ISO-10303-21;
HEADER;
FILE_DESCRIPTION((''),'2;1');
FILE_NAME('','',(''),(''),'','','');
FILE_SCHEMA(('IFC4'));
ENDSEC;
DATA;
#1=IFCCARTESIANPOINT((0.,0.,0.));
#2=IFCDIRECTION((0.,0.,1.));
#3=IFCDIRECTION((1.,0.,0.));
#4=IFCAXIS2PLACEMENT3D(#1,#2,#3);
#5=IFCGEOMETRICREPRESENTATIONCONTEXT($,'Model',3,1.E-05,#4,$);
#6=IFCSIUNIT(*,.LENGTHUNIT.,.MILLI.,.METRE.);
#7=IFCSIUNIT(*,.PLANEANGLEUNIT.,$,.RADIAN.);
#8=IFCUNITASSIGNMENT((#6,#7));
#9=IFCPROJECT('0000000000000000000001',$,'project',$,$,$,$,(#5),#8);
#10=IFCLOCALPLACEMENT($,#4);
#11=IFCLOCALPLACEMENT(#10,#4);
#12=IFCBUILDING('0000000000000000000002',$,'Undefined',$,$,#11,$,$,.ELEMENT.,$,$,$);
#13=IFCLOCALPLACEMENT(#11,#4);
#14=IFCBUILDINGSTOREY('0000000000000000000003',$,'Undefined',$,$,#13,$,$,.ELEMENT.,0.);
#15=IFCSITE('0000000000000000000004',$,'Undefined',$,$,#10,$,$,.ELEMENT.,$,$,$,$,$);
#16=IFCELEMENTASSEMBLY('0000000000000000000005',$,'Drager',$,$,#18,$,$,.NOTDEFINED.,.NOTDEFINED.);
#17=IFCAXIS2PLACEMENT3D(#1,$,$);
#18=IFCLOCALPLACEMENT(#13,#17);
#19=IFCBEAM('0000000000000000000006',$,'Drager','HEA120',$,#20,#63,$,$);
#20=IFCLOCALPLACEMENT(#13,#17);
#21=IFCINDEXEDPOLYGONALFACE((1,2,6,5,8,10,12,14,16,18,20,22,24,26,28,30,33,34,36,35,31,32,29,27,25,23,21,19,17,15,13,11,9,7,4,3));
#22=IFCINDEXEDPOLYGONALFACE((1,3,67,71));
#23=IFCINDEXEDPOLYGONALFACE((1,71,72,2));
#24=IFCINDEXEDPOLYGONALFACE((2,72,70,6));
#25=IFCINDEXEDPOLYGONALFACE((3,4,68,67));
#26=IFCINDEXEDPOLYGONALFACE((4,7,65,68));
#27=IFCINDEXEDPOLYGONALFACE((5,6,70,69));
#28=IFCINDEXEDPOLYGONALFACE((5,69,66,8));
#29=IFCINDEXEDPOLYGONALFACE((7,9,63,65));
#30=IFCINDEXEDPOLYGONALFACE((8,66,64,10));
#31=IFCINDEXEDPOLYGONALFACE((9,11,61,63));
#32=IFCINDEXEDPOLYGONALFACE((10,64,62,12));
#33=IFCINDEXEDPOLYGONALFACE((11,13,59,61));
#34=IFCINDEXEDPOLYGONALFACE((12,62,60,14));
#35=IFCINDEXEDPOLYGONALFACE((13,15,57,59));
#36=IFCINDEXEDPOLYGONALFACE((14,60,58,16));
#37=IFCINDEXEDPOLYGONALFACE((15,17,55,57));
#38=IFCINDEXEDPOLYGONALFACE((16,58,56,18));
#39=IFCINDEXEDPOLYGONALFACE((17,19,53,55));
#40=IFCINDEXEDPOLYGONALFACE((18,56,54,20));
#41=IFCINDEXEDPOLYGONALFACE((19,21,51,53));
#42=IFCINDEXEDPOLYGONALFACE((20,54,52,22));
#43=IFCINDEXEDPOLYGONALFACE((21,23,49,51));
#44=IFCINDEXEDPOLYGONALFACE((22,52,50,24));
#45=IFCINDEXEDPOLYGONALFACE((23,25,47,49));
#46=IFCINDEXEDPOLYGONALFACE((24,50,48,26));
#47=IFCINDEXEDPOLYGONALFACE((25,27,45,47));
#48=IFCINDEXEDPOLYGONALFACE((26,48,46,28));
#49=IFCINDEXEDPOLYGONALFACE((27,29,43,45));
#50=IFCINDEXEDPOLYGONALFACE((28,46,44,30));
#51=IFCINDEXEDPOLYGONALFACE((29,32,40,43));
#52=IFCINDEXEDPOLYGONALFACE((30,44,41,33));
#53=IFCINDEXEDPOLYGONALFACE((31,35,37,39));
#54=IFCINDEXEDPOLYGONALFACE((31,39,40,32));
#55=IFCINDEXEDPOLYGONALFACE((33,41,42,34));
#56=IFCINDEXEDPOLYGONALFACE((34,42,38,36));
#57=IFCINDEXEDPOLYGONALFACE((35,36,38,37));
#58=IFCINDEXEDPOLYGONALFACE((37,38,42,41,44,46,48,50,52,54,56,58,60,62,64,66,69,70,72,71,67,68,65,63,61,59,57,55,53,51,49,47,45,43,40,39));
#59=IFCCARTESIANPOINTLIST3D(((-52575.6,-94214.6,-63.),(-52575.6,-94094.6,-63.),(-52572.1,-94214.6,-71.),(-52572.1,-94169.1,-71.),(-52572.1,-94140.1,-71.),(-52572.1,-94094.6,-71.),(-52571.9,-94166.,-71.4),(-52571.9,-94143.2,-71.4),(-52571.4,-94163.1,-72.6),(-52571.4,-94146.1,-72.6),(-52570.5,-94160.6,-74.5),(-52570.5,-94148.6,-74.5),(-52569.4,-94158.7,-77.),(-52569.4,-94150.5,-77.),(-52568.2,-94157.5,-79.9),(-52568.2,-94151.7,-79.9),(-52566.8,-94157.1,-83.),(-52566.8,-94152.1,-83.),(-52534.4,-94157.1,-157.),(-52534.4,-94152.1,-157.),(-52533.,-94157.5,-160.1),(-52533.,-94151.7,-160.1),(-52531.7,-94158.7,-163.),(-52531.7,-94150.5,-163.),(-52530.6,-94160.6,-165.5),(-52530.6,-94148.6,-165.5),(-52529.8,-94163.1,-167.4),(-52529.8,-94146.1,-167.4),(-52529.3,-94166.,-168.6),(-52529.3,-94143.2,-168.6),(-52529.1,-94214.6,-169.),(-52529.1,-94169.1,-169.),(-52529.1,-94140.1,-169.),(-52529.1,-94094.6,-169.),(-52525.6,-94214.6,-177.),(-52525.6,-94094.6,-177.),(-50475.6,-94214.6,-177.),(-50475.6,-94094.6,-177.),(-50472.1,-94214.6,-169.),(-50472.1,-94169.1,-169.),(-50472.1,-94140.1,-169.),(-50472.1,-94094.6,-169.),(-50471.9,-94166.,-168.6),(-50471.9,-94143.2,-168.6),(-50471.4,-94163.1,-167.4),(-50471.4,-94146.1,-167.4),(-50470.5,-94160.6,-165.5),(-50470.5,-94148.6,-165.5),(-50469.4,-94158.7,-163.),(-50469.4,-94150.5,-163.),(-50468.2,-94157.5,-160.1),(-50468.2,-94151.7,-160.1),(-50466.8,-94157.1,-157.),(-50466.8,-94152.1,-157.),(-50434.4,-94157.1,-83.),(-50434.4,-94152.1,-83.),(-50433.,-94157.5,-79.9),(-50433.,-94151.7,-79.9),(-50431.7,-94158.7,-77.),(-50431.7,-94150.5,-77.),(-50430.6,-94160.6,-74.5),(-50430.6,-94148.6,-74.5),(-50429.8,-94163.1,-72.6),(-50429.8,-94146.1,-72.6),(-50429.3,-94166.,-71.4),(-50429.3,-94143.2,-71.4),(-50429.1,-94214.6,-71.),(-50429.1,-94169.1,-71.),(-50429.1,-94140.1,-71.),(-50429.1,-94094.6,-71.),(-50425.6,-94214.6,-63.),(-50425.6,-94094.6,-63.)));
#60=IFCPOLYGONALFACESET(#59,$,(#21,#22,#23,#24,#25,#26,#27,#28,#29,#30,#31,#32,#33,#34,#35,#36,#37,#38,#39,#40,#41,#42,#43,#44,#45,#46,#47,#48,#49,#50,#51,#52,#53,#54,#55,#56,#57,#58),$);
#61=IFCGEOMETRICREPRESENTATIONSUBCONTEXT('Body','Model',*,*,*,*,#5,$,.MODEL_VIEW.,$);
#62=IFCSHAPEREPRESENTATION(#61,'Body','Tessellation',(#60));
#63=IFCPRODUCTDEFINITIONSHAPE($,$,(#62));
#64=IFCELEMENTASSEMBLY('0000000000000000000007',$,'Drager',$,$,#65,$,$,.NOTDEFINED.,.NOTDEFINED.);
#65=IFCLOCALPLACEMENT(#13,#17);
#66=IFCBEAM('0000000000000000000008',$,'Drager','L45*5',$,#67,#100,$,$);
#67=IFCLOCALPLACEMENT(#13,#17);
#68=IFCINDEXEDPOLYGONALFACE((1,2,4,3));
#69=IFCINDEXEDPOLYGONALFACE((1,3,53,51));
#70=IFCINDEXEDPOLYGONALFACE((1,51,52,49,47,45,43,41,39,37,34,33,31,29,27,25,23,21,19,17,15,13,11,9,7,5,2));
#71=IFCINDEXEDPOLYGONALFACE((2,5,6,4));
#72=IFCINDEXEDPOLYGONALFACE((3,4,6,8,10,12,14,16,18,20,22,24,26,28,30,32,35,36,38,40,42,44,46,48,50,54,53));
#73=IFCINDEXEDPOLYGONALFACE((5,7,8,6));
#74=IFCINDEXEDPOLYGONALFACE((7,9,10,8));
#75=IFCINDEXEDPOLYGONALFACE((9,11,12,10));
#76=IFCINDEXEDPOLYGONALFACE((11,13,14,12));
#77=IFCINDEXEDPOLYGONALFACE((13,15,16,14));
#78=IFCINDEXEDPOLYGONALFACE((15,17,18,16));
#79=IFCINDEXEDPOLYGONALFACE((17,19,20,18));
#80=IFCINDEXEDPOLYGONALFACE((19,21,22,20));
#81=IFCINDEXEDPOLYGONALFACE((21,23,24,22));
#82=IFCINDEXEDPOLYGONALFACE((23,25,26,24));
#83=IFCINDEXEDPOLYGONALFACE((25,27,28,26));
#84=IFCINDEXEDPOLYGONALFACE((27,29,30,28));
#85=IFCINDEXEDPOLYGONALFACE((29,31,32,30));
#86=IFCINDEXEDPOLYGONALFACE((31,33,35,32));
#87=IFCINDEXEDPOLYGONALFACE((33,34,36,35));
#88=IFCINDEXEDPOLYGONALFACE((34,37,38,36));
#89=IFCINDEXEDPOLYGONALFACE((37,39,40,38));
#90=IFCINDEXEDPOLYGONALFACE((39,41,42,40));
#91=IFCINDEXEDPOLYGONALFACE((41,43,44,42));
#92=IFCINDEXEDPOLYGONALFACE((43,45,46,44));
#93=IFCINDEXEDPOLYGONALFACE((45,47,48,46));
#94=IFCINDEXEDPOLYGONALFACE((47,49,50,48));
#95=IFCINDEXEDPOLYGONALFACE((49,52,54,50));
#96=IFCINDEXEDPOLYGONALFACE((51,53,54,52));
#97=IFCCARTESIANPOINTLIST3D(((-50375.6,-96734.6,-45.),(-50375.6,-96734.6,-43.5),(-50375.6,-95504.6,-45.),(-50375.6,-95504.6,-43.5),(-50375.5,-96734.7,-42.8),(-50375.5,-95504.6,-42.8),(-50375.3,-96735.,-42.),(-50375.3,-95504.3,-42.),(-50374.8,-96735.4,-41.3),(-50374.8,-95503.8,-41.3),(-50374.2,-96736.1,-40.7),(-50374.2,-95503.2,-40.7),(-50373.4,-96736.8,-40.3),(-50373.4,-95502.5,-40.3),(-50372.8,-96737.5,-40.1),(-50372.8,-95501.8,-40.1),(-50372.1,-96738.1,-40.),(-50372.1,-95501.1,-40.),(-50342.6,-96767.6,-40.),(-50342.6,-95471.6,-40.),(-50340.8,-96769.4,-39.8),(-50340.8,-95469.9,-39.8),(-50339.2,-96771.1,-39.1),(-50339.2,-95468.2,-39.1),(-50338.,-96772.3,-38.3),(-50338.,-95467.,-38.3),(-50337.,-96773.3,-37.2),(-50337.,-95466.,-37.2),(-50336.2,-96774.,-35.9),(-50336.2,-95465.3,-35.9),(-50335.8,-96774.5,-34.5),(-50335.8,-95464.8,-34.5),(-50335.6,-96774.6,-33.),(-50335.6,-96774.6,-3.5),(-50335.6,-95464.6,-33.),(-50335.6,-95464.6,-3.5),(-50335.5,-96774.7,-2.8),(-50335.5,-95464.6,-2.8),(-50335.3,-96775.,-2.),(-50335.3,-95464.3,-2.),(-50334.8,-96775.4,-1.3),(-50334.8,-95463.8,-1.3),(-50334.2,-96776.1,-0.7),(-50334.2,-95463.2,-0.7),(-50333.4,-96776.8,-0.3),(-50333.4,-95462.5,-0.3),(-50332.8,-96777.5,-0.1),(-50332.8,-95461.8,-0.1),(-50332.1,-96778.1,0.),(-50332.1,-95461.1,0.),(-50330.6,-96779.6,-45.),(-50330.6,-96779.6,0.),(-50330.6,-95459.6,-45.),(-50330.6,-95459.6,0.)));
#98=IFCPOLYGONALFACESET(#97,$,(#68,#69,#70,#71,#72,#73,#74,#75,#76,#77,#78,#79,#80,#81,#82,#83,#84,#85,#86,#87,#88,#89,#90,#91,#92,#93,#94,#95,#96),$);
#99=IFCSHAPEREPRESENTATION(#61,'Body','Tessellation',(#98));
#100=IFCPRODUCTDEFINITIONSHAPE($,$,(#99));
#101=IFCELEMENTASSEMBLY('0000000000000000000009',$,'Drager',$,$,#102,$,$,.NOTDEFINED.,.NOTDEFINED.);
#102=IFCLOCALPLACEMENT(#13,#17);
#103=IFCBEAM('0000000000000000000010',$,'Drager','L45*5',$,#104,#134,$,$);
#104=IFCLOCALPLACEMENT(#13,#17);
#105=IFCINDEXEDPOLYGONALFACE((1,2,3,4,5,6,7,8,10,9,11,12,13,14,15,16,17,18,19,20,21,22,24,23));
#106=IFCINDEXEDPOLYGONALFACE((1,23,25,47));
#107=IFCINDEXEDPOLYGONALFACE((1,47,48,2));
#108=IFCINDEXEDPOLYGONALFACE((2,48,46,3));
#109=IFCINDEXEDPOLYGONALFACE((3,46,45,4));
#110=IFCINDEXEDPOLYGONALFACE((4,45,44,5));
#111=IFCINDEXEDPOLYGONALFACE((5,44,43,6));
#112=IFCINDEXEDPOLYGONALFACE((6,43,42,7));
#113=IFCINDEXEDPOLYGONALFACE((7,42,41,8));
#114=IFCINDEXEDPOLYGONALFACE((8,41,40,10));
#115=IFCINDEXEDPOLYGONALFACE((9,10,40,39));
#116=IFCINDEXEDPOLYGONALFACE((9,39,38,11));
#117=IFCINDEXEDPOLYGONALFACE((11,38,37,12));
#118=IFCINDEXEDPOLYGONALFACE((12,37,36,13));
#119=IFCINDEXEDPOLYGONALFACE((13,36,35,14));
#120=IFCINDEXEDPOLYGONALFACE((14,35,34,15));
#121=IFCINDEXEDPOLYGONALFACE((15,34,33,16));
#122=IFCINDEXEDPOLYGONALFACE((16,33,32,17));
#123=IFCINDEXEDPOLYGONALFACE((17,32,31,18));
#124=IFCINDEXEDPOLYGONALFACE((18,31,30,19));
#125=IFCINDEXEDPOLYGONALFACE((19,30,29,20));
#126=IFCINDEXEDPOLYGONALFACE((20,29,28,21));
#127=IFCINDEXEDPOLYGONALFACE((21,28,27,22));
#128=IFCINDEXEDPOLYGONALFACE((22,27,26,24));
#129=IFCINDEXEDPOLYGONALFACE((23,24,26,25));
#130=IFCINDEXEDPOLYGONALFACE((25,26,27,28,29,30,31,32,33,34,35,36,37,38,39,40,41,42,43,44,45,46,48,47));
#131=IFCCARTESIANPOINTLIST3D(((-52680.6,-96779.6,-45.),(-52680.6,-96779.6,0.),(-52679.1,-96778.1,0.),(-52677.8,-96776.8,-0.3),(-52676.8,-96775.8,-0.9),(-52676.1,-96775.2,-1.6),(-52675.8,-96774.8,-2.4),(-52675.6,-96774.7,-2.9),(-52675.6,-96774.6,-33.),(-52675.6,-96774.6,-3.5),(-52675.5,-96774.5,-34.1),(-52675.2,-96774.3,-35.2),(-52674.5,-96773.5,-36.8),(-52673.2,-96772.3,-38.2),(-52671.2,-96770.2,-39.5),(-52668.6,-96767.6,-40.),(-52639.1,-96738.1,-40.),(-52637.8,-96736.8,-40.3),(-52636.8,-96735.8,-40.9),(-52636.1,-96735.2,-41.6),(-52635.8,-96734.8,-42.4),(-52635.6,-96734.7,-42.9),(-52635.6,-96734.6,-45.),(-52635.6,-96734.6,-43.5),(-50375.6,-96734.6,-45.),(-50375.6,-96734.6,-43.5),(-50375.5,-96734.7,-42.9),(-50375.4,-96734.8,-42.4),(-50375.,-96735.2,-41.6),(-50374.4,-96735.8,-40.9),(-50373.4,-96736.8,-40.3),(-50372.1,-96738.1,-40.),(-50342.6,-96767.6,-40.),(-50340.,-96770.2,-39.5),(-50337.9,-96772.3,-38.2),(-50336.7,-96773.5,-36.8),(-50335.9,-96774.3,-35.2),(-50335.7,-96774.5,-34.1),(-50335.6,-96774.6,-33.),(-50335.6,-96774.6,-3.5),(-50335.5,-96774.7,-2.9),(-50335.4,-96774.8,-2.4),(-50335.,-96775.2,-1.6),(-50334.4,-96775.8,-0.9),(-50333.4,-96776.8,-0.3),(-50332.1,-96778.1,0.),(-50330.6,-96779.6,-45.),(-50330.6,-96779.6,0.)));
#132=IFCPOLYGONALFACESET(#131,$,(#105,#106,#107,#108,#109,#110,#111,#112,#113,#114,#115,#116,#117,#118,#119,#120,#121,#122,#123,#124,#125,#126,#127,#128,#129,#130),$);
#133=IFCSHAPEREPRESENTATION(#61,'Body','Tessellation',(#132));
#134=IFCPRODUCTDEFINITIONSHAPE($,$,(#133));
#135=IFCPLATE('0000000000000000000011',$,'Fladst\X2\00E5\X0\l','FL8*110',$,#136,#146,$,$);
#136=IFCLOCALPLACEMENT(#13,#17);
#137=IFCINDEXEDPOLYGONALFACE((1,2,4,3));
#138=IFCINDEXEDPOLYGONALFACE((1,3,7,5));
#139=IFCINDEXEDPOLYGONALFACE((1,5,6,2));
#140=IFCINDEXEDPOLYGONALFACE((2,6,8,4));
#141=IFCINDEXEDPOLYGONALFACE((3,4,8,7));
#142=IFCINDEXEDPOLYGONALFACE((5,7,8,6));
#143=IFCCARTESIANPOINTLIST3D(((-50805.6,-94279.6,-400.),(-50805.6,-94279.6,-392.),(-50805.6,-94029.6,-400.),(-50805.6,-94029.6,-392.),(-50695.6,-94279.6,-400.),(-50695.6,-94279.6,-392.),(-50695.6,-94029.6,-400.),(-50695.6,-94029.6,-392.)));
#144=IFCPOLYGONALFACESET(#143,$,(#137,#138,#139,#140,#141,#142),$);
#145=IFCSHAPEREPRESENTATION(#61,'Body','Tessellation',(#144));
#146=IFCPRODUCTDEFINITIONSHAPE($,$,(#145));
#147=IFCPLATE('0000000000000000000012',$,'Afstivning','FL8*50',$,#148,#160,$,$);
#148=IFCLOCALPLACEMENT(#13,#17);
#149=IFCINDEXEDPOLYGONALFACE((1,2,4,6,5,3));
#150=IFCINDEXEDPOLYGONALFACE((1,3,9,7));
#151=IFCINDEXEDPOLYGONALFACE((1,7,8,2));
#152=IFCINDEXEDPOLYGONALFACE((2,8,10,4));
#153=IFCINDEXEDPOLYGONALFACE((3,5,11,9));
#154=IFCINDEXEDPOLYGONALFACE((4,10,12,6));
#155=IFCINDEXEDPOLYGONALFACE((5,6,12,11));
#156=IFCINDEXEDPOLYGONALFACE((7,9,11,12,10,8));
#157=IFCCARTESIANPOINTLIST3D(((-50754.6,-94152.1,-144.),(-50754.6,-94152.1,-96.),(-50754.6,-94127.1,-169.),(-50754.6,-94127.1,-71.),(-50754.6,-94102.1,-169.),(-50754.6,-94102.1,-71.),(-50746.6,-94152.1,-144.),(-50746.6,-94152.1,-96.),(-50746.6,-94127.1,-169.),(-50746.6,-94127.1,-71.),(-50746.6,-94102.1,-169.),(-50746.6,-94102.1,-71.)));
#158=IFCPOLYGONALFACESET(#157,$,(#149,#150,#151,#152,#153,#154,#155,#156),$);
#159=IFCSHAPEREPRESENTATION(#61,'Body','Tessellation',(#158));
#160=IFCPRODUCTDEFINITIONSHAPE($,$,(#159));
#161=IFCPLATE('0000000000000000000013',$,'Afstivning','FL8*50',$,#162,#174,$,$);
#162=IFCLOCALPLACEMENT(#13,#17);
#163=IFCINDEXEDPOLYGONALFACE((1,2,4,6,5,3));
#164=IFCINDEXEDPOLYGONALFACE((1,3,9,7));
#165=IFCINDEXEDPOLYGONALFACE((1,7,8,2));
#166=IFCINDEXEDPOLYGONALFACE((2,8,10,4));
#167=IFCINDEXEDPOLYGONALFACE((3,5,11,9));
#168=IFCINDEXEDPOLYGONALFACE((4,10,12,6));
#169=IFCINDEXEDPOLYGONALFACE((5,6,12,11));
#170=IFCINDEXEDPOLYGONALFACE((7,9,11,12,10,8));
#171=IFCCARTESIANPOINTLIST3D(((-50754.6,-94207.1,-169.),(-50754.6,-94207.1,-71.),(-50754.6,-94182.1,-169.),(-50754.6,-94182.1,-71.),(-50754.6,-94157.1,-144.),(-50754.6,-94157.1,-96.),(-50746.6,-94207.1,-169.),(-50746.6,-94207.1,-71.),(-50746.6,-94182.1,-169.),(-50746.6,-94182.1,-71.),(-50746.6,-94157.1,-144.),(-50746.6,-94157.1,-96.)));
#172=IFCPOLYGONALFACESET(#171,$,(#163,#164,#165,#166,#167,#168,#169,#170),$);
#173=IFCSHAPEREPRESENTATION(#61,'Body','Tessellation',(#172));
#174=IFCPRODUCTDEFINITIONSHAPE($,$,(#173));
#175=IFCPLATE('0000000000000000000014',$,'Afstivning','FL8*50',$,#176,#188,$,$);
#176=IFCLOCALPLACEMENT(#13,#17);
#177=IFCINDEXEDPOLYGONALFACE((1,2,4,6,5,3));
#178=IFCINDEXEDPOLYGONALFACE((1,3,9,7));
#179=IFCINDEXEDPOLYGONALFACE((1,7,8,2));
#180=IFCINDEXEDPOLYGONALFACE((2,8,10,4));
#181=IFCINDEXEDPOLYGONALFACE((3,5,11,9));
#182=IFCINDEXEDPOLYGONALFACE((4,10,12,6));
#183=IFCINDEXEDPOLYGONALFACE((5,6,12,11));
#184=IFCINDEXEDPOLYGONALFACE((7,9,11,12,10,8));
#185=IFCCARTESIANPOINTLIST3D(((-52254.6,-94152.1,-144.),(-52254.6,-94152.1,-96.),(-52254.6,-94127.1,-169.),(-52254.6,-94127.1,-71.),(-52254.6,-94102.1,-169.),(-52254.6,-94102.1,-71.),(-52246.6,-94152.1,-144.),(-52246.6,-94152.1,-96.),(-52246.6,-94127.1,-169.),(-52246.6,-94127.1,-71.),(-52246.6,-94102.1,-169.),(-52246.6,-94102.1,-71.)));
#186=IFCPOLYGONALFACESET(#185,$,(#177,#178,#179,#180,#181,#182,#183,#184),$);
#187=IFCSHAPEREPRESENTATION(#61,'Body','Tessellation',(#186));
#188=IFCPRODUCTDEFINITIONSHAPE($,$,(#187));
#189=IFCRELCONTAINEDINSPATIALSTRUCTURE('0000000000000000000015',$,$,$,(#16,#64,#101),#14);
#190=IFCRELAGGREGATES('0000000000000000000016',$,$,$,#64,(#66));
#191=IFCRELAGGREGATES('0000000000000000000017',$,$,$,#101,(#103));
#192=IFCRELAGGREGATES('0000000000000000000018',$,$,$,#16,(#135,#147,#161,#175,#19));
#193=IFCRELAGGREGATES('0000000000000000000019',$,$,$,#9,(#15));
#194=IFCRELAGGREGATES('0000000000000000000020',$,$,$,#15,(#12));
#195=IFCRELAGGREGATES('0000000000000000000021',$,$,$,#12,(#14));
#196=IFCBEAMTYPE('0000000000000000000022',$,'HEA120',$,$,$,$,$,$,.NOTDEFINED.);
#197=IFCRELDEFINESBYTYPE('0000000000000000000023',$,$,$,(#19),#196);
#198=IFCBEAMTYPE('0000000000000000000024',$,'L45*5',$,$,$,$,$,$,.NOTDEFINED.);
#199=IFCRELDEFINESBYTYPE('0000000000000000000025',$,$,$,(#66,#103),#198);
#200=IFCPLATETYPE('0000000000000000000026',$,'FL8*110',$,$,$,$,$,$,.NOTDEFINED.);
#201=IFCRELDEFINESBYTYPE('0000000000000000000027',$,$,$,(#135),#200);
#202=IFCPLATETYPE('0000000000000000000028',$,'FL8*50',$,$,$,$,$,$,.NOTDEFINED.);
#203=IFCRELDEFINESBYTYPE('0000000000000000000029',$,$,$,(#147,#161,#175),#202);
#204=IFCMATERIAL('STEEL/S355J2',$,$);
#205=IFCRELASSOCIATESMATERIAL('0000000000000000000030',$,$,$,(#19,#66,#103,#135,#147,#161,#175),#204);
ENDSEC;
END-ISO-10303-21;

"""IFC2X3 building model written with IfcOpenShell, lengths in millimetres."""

from ifc_helpers import new_model, si_unit, frame, origin_with_axes, origin_2d_with_axis, place, context, subcontext, project, spatial, polyline, i_section, l_section, outline, extrude, clip, halfspace, material, type_object, element, aggregate, save


model = new_model("IFC2X3")

# Units and contexts
model_context = context("Model", 3, precision=1e-05, world=origin_with_axes())
body_context = subcontext(model_context, "Body", "Model", "MODEL_VIEW")
ifc_project = project(units=[si_unit("LENGTHUNIT", "METRE", prefix="MILLI"), si_unit("PLANEANGLEUNIT", "RADIAN")], contexts=[model_context])

# Site, building, storey
site_placement = place(None, origin_with_axes())
site = spatial("IfcSite", under=ifc_project, at=site_placement, Name="Undefined", CompositionType="ELEMENT")
building_placement = place(site_placement, origin_with_axes())
building = spatial("IfcBuilding", under=site, at=building_placement, Name="Undefined", CompositionType="ELEMENT")
storey_placement = place(building_placement, origin_with_axes())
storey = spatial("IfcBuildingStorey", under=building, at=storey_placement, Name="Undefined", CompositionType="ELEMENT", Elevation=0.0)

# Shared definitions
ifc_material_1 = material(Name="STEEL/S355J2")

# Element assembly, beam
assembly_1_placement = place(storey_placement, origin_with_axes())
assembly_1 = element("IfcElementAssembly", 1, at=assembly_1_placement, inside=storey, Name="Drager", AssemblyPlace="NOTDEFINED", PredefinedType="NOTDEFINED")
beam_type_1 = type_object("IfcBeamType", Name="HEA120", PredefinedType="NOTDEFINED")
beam_1_placement = place(assembly_1_placement, frame((-50425.6, -94154.6, -120.0), z_axis=(0.0, 0.0, -1.0), x_axis=(-1.0, 0.0, 0.0)))
beam_1 = element("IfcBeam", 2, at=beam_1_placement, type_object=beam_type_1, material=ifc_material_1, Name="Drager", Description="HEA120", context=body_context, shape_type="Clipping", body=[
    clip(clip(extrude(i_section(OverallWidth=120.0, OverallDepth=114.0, WebThickness=5.0, FlangeThickness=8.0, FilletRadius=12.0, at=origin_2d_with_axis()), frame((2150.0, 0.0, 0.0), z_axis=(-1.0, 0.0, 0.0), x_axis=(0.0, -1.0, 0.0)), (0.0, 0.0, 1.0), 2150.0), halfspace(frame((50.0, 60.0, 57.0), z_axis=(-0.915788, 0.0, 0.401661), x_axis=(0.0, -1.0, 0.0)), False)), halfspace(frame((2100.0, 60.0, 57.0), z_axis=(0.915788, 0.0, 0.401661), x_axis=(0.401661, 0.0, -0.915788)), False)),
])

# Element assemblies, beams
assembly_2_placement = place(storey_placement, origin_with_axes())
assembly_2 = element("IfcElementAssembly", 3, at=assembly_2_placement, inside=storey, Name="Drager", AssemblyPlace="NOTDEFINED", PredefinedType="NOTDEFINED")
beam_type_2 = type_object("IfcBeamType", Name="L45*5", PredefinedType="NOTDEFINED")
beam_2_placement = place(assembly_2_placement, frame((-50353.1, -95504.6, -22.5), z_axis=(0.0, 0.0, 1.0), x_axis=(0.0, -1.0, 0.0)))
beam_2 = element("IfcBeam", 4, at=beam_2_placement, type_object=beam_type_2, material=ifc_material_1, Name="Drager", Description="L45*5", context=body_context, shape_type="Clipping", body=[
    clip(clip(extrude(l_section(Depth=45.0, Width=45.0, Thickness=5.0, FilletRadius=7.0, EdgeRadius=3.5, at=origin_2d_with_axis()), frame((1297.9, 0.0, 0.0), z_axis=(-1.0, 0.0, 0.0), x_axis=(0.0, -1.0, 0.0)), (0.0, 0.0, 1.0), 1365.9), halfspace(frame((1230.0, -22.5, 22.5), z_axis=(-0.707107, 0.707107, 0.0), x_axis=(0.707107, 0.707107, 0.0)), True)), halfspace(frame((0.0, -22.5, 22.5), z_axis=(-0.707107, -0.707107, 0.0), x_axis=(-0.707107, 0.707107, 0.0)), False)),
])
aggregate(assembly_2, [beam_2])
assembly_3_placement = place(storey_placement, origin_with_axes())
assembly_3 = element("IfcElementAssembly", 5, at=assembly_3_placement, inside=storey, Name="Drager", AssemblyPlace="NOTDEFINED", PredefinedType="NOTDEFINED")
beam_3_placement = place(assembly_3_placement, frame((-50375.6, -96757.1, -22.5), z_axis=(0.0, 0.0, 1.0), x_axis=(-1.0, 0.0, 0.0)))
beam_3 = element("IfcBeam", 6, at=beam_3_placement, type_object=beam_type_2, material=ifc_material_1, Name="Drager", Description="L45*5", context=body_context, shape_type="Clipping", body=[
    clip(clip(extrude(l_section(Depth=45.0, Width=45.0, Thickness=5.0, FilletRadius=7.0, EdgeRadius=3.5, at=origin_2d_with_axis()), frame((2327.9, 0.0, 0.0), z_axis=(-1.0, 0.0, 0.0), x_axis=(0.0, -1.0, 0.0)), (0.0, 0.0, 1.0), 2395.9), halfspace(frame((2260.0, -22.5, 22.5), z_axis=(0.707107, -0.707107, 0.0), x_axis=(0.0, 0.0, 1.0)), False)), halfspace(frame((0.0, -22.5, 22.5), z_axis=(0.707107, 0.707107, 0.0), x_axis=(0.0, 0.0, 1.0)), True)),
])
aggregate(assembly_3, [beam_3])

# Plates
plate_type_1 = type_object("IfcPlateType", Name="FL8*110", PredefinedType="NOTDEFINED")
plate_1_placement = place(assembly_1_placement, frame((-50805.6, -94154.6, -396.0), z_axis=(0.0, 0.0, 1.0), x_axis=(1.0, 0.0, 0.0)))
plate_1 = element("IfcPlate", 7, at=plate_1_placement, type_object=plate_type_1, material=ifc_material_1, Name="Fladstål", Description="FL8*110", context=body_context, shape_type="SweptSolid", body=[
    extrude(outline(polyline([(0.0, -125.0), (0.0, 125.0), (110.0, 125.0), (110.0, -125.0), (0.0, -125.0)])), frame((0.0, 0.0, -4.0), z_axis=(0.0, 0.0, 1.0), x_axis=(1.0, 0.0, 0.0)), (0.0, 0.0, 1.0), 8.0),
])
plate_type_2 = type_object("IfcPlateType", Name="FL8*50", PredefinedType="NOTDEFINED")
plate_2_placement = place(assembly_1_placement, frame((-50750.6, -94152.1, -71.0), z_axis=(-1.0, 0.0, 0.0), x_axis=(0.0, 1.0, 0.0)))
plate_2 = element("IfcPlate", 8, at=plate_2_placement, type_object=plate_type_2, material=ifc_material_1, Name="Afstivning", Description="FL8*50", context=body_context, shape_type="SweptSolid", body=[
    extrude(outline(polyline([(0.0, 25.0), (25.0, 0.0), (50.0, 0.0), (50.0, 98.0), (25.0, 98.0), (0.0, 73.0), (0.0, 25.0)])), frame((0.0, 0.0, -4.0), z_axis=(0.0, 0.0, 1.0), x_axis=(1.0, 0.0, 0.0)), (0.0, 0.0, 1.0), 8.0),
])
plate_3_placement = place(assembly_1_placement, frame((-50750.6, -94157.1, -71.0), z_axis=(1.0, 0.0, 0.0), x_axis=(0.0, -1.0, 0.0)))
plate_3 = element("IfcPlate", 9, at=plate_3_placement, type_object=plate_type_2, material=ifc_material_1, Name="Afstivning", Description="FL8*50", context=body_context, shape_type="SweptSolid", body=[
    extrude(outline(polyline([(0.0, 25.0), (25.0, 0.0), (50.0, 0.0), (50.0, 98.0), (25.0, 98.0), (0.0, 73.0), (0.0, 25.0)])), frame((0.0, 0.0, -4.0), z_axis=(0.0, 0.0, 1.0), x_axis=(1.0, 0.0, 0.0)), (0.0, 0.0, 1.0), 8.0),
])
plate_4_placement = place(assembly_1_placement, frame((-52250.6, -94152.1, -71.0), z_axis=(-1.0, 0.0, 0.0), x_axis=(0.0, 1.0, 0.0)))
plate_4 = element("IfcPlate", 10, at=plate_4_placement, type_object=plate_type_2, material=ifc_material_1, Name="Afstivning", Description="FL8*50", context=body_context, shape_type="SweptSolid", body=[
    extrude(outline(polyline([(0.0, 25.0), (25.0, 0.0), (50.0, 0.0), (50.0, 98.0), (25.0, 98.0), (0.0, 73.0), (0.0, 25.0)])), frame((0.0, 0.0, -4.0), z_axis=(0.0, 0.0, 1.0), x_axis=(1.0, 0.0, 0.0)), (0.0, 0.0, 1.0), 8.0),
])

aggregate(assembly_1, [plate_1, plate_2, plate_3, plate_4, beam_1])

save(model, "model.ifc")
